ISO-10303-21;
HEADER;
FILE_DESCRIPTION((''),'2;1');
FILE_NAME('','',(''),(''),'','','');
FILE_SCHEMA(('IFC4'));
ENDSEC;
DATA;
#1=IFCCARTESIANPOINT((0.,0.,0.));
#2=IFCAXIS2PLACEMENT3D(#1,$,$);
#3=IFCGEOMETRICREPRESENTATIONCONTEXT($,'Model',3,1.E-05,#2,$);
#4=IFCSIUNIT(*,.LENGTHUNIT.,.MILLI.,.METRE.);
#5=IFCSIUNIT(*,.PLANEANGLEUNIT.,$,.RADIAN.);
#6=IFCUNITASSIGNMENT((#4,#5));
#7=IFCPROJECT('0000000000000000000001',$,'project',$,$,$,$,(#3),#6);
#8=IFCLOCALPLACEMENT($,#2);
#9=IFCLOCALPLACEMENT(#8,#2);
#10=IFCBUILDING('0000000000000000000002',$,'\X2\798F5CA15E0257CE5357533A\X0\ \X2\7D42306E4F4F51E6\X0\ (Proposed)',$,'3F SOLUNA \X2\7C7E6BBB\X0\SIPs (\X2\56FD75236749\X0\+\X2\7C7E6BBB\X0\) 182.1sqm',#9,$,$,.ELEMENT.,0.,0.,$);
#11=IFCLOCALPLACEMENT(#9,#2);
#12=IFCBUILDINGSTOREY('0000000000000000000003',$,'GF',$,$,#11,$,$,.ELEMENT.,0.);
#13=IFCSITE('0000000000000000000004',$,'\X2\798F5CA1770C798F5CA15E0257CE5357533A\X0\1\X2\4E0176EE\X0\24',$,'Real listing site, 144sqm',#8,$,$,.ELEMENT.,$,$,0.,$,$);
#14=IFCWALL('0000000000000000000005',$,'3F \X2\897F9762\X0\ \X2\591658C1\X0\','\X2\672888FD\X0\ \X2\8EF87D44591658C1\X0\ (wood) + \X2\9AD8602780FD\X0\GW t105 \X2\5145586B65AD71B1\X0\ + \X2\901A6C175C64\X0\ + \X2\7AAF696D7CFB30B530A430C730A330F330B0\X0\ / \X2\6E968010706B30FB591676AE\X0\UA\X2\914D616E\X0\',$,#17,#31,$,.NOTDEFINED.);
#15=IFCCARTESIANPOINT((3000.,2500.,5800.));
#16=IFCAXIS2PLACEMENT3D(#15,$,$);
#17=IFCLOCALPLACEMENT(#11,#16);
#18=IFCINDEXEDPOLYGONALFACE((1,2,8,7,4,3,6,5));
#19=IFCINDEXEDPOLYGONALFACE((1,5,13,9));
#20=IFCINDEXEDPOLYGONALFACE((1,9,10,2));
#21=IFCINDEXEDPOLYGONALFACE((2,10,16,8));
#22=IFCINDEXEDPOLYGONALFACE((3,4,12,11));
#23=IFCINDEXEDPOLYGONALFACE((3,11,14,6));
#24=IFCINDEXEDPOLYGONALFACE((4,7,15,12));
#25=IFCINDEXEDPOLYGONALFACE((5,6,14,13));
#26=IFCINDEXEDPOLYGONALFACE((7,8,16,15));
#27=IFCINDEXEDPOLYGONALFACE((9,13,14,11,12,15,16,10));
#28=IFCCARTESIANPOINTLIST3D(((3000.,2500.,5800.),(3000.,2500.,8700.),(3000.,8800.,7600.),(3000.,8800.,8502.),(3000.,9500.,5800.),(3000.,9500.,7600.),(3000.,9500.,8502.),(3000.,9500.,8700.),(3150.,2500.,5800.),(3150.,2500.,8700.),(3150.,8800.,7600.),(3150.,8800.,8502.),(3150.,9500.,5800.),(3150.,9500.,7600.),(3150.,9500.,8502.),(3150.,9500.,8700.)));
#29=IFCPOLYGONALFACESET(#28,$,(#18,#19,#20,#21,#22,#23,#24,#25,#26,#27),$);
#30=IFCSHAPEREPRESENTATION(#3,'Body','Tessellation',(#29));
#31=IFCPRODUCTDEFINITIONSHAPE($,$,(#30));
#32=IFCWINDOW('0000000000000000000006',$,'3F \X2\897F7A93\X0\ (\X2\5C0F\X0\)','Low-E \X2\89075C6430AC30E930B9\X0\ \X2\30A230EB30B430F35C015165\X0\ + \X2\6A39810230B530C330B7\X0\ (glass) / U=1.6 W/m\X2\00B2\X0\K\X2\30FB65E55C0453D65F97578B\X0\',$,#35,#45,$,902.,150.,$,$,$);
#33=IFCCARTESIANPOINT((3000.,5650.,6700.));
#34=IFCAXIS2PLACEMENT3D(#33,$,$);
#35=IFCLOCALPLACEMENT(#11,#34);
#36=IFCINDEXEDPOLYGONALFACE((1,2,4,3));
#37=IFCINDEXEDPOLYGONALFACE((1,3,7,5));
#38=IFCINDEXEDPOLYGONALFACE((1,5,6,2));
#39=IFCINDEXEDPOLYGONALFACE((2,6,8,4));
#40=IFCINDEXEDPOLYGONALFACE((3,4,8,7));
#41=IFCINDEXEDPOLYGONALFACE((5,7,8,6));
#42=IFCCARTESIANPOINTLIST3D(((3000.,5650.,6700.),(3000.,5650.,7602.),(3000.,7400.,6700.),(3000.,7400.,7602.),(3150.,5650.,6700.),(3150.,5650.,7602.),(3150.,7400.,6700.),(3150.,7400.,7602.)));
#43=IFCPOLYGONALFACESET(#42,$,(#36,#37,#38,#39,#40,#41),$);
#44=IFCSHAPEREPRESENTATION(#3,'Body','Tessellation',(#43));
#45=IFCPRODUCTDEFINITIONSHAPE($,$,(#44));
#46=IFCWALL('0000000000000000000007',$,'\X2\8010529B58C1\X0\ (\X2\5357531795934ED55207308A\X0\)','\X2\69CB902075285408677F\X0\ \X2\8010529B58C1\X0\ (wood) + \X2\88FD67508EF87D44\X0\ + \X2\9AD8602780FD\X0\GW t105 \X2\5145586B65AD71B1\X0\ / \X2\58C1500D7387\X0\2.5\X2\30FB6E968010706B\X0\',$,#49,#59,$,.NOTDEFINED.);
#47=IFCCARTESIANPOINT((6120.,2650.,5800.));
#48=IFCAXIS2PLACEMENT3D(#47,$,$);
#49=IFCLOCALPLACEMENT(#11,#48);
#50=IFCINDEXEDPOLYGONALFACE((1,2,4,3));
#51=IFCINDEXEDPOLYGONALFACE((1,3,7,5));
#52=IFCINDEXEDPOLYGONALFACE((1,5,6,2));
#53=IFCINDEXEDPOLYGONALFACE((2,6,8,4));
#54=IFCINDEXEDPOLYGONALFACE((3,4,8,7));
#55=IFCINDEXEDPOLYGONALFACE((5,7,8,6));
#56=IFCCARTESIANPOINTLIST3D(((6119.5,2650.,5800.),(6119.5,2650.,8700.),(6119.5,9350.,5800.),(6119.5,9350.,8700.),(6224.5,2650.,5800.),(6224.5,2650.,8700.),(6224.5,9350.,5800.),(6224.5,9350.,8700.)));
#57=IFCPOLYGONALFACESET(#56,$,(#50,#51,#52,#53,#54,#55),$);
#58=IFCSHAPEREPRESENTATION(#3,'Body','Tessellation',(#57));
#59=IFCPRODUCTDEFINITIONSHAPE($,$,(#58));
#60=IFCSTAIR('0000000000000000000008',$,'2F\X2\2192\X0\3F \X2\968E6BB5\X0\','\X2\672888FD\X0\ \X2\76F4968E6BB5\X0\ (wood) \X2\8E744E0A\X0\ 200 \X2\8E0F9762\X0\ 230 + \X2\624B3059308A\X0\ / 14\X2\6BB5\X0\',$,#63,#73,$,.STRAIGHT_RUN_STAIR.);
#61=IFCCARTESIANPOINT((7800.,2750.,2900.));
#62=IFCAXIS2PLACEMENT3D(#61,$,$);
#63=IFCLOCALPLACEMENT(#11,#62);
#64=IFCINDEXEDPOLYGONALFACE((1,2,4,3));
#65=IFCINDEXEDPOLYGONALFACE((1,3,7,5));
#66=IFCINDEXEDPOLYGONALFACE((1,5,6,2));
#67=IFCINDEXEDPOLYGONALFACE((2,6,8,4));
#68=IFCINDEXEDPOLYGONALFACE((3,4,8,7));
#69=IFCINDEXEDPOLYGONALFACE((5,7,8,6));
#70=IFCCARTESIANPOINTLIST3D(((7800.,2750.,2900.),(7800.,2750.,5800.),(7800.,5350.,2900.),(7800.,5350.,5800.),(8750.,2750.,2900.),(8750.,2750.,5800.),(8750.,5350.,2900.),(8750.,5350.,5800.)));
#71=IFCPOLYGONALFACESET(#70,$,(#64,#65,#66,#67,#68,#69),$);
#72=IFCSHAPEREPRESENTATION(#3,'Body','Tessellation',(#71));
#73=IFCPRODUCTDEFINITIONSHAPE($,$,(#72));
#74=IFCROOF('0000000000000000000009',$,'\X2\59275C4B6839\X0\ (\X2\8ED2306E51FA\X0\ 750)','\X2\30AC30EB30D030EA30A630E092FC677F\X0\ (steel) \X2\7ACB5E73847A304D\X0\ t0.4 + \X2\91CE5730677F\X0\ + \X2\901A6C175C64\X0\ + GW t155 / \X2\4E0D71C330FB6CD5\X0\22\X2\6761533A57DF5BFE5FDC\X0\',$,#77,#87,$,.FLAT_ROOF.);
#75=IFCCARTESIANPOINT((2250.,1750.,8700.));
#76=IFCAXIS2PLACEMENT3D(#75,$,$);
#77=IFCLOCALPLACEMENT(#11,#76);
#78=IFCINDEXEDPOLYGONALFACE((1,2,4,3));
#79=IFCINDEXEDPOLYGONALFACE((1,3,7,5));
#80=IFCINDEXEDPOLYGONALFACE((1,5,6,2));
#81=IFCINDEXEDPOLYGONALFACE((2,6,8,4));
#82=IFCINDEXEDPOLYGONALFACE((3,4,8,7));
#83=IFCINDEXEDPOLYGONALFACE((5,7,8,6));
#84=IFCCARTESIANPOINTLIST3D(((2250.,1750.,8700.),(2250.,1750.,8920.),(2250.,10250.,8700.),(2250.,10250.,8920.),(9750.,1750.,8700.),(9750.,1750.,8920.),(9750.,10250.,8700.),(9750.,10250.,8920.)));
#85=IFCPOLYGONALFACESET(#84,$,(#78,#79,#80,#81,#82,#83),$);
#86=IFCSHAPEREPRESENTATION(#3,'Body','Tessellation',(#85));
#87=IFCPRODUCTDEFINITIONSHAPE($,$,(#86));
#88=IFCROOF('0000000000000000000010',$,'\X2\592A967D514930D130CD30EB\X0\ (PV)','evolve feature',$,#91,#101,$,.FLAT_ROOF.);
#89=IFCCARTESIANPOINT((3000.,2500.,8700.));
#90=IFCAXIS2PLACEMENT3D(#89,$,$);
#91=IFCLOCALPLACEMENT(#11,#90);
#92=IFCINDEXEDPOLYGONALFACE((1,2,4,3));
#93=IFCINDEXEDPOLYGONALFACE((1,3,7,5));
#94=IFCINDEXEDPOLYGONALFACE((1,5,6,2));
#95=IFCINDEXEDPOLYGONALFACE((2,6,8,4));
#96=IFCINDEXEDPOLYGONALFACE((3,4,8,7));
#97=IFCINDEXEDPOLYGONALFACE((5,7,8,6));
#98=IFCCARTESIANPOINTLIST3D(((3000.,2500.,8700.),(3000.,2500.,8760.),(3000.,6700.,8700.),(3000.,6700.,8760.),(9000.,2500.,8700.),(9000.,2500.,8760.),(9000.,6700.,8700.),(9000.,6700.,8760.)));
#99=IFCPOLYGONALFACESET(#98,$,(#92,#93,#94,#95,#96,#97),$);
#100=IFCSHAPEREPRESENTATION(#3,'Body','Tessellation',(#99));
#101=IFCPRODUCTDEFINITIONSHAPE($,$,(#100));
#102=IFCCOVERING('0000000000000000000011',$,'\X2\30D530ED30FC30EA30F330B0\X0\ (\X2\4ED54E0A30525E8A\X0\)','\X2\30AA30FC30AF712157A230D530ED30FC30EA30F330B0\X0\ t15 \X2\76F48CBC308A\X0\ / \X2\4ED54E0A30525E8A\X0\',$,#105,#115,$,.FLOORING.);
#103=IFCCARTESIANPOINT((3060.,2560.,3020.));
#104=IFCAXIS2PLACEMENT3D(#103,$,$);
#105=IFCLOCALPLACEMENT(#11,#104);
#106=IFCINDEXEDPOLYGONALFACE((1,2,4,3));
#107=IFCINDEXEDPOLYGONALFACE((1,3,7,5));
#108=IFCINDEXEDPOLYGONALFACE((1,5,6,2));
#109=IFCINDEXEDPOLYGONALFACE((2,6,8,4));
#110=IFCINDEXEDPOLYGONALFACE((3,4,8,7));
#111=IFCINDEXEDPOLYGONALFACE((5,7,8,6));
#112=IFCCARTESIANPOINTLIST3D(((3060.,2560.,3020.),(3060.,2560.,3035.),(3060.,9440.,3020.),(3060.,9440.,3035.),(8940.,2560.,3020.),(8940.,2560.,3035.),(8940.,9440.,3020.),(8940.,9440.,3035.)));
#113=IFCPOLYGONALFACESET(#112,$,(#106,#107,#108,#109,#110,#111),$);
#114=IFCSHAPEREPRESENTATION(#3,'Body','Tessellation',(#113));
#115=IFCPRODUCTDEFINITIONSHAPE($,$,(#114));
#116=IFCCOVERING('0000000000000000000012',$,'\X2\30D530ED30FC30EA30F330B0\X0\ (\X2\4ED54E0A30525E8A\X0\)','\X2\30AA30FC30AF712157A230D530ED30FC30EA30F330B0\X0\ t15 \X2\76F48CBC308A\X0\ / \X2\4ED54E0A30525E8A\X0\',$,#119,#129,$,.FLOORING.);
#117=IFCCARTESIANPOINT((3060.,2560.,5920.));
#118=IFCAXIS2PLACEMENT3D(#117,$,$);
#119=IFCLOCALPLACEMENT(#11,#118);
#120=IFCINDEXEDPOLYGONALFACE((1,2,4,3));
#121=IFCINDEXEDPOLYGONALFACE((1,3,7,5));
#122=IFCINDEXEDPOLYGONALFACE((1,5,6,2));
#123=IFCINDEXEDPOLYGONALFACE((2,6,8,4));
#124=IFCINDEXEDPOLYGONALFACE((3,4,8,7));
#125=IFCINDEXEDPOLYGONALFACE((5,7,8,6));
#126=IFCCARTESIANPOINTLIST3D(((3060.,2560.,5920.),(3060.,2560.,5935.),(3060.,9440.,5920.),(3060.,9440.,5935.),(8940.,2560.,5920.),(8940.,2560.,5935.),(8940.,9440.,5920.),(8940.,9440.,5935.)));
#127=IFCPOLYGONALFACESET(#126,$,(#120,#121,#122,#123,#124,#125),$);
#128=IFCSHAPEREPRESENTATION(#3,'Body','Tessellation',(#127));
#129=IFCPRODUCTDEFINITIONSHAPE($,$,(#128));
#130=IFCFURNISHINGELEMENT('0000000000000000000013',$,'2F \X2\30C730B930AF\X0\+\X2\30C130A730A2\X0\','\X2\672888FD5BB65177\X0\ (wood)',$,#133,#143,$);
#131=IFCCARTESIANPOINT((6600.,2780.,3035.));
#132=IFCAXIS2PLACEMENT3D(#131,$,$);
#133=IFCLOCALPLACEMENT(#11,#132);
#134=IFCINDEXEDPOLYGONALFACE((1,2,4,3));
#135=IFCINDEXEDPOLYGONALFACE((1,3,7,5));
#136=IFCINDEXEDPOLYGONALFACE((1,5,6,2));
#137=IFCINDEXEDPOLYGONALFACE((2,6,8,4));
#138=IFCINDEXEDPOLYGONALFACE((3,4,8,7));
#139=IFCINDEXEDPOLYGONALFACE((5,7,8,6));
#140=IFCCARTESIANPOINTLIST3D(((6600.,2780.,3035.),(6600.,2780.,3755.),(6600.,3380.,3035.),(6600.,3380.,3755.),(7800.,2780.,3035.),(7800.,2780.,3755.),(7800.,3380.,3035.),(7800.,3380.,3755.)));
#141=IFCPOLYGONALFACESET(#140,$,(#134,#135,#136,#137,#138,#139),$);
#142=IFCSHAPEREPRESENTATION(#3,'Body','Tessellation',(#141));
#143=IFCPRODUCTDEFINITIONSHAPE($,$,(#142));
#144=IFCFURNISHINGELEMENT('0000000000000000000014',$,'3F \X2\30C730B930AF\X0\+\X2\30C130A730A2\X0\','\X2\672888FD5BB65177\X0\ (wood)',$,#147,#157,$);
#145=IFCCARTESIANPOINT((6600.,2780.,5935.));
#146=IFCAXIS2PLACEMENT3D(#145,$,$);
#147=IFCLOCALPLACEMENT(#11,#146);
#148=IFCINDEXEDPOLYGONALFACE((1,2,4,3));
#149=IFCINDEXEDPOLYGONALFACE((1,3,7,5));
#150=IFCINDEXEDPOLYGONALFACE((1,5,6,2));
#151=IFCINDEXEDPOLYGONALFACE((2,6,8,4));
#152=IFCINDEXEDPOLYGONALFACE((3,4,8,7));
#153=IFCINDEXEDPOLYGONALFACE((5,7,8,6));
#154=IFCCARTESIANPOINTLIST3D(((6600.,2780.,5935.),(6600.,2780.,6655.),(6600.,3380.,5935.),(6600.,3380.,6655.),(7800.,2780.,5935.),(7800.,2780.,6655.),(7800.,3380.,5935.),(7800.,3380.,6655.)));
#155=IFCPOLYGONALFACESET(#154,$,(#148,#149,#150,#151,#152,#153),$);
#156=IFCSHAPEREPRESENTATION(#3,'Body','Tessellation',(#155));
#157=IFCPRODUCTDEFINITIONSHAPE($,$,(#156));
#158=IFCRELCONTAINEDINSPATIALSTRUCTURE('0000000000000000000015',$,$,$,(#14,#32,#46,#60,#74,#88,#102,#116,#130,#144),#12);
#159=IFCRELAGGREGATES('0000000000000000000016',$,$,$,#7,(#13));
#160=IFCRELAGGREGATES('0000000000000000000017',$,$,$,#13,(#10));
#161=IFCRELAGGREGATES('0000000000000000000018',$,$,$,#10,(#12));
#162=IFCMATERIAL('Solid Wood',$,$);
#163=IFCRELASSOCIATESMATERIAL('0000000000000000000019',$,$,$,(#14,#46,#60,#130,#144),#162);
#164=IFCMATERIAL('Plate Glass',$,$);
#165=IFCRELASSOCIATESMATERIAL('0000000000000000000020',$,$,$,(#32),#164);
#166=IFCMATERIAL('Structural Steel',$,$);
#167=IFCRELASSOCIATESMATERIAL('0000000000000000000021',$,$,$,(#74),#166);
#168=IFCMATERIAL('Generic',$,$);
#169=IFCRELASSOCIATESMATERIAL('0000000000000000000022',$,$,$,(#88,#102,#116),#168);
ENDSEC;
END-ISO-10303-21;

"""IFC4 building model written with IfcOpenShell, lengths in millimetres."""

from ifc_helpers import new_model, si_unit, frame, frame_2d, origin, place, context, project, spatial, rectangle, extrude, material, element, fill, save


model = new_model("IFC4")

# Units and contexts
model_context = context("Model", 3, precision=1e-05, world=origin())
ifc_project = project(units=[si_unit("LENGTHUNIT", "METRE", prefix="MILLI"), si_unit("PLANEANGLEUNIT", "RADIAN")], contexts=[model_context])

# Site, building, storey
site_placement = place(None, origin())
site = spatial("IfcSite", under=ifc_project, at=site_placement, Name="福岡県福岡市城南区1丁目24", ObjectType="Real listing site, 144sqm", CompositionType="ELEMENT", RefElevation=0.0)
building_placement = place(site_placement, origin())
building = spatial("IfcBuilding", under=site, at=building_placement, Name="福岡市城南区 終の住処 (Proposed)", ObjectType="3F SOLUNA 籾殻SIPs (国産杉+籾殻) 182.1sqm", CompositionType="ELEMENT", ElevationOfRefHeight=0.0, ElevationOfTerrain=0.0)
storey_placement = place(building_placement, origin())
storey = spatial("IfcBuildingStorey", under=building, at=storey_placement, Name="GF", CompositionType="ELEMENT", Elevation=0.0)

# Shared definitions
ifc_material_1 = material(Name="Solid Wood")

# Shared definitions
ifc_material_2 = material(Name="Plate Glass")

# Shared definitions
ifc_material_3 = material(Name="Generic")

# Wall, opening, window
wall_1_placement = place(storey_placement, frame((3000.0, 2500.0, 5800.0)))
wall_1 = element("IfcWall", 1, at=wall_1_placement, inside=storey, material=ifc_material_1, Name="3F 西面 外壁", Description="木製 軸組外壁 (wood) + 高性能GW t105 充填断熱 + 通気層 + 窯業系サイディング / 準耐火・外皮UA配慮", PredefinedType="NOTDEFINED", context=model_context, shape_type="SweptSolid", body=[
    extrude(rectangle(XDim=150.0, YDim=7000.0, at=frame_2d((75.0, 3500.0))), frame((3000.0, 2500.0, 5800.0)), (0.0, 0.0, 1.0), 2900.0),
])
opening_1_placement = place(storey_placement, frame((3000.0, 5650.0, 6700.0)))
opening_1 = element("IfcOpeningElement", 2, at=opening_1_placement, cuts=wall_1, PredefinedType="NOTDEFINED", context=model_context, shape_type="SweptSolid", body=[
    extrude(rectangle(XDim=150.0, YDim=1750.0, at=frame_2d((75.0, 875.0))), frame((3000.0, 5650.0, 6700.0)), (0.0, 0.0, 1.0), 902.0),
])
window_1_placement = place(storey_placement, frame((3000.0, 5650.0, 6700.0)))
window_1 = element("IfcWindow", 3, at=window_1_placement, inside=storey, material=ifc_material_2, Name="3F 西窓 (小)", Description="Low-E 複層ガラス アルゴン封入 + 樹脂サッシ (glass) / U=1.6 W/m²K・日射取得型", OverallHeight=902.0, OverallWidth=150.0, context=model_context, shape_type="SweptSolid", body=[
    extrude(rectangle(XDim=150.0, YDim=1750.0, at=frame_2d((75.0, 875.0))), frame((3000.0, 5650.0, 6700.0)), (0.0, 0.0, 1.0), 902.0),
])
fill(opening_1, window_1)

# Wall
wall_2_placement = place(storey_placement, frame((6120.0, 2650.0, 5800.0)))
element("IfcWall", 4, at=wall_2_placement, inside=storey, material=ifc_material_1, Name="耐力壁 (南北間仕切り)", Description="構造用合板 耐力壁 (wood) + 製材軸組 + 高性能GW t105 充填断熱 / 壁倍率2.5・準耐火", PredefinedType="NOTDEFINED", context=model_context, shape_type="SweptSolid", body=[
    extrude(rectangle(XDim=105.0, YDim=6700.0, at=frame_2d((52.0, 3350.0))), frame((6120.0, 2650.0, 5800.0)), (0.0, 0.0, 1.0), 2900.0),
])

# Stair
stair_placement = place(storey_placement, frame((7800.0, 2750.0, 2900.0)))
element("IfcStair", 5, at=stair_placement, inside=storey, material=ifc_material_1, Name="2F→3F 階段", Description="木製 直階段 (wood) 蹴上 200 踏面 230 + 手すり / 14段", PredefinedType="STRAIGHT_RUN_STAIR", context=model_context, shape_type="SweptSolid", body=[
    extrude(rectangle(XDim=950.0, YDim=2600.0, at=frame_2d((475.0, 1300.0))), frame((7800.0, 2750.0, 2900.0)), (0.0, 0.0, 1.0), 2900.0),
])

# Roofs
ifc_material_4 = material(Name="Structural Steel")
roof_1_placement = place(storey_placement, frame((2250.0, 1750.0, 8700.0)))
element("IfcRoof", 6, at=roof_1_placement, inside=storey, material=ifc_material_4, Name="大屋根 (軒の出 750)", Description="ガルバリウム鋼板 (steel) 立平葺き t0.4 + 野地板 + 通気層 + GW t155 / 不燃・法22条区域対応", PredefinedType="FLAT_ROOF", context=model_context, shape_type="SweptSolid", body=[
    extrude(rectangle(XDim=7500.0, YDim=8500.0, at=frame_2d((3750.0, 4250.0))), frame((2250.0, 1750.0, 8700.0)), (0.0, 0.0, 1.0), 220.0),
])
roof_2_placement = place(storey_placement, frame((3000.0, 2500.0, 8700.0)))
element("IfcRoof", 7, at=roof_2_placement, inside=storey, material=ifc_material_3, Name="太陽光パネル (PV)", Description="evolve feature", PredefinedType="FLAT_ROOF", context=model_context, shape_type="SweptSolid", body=[
    extrude(rectangle(XDim=6000.0, YDim=4200.0, at=frame_2d((3000.0, 2100.0))), frame((3000.0, 2500.0, 8700.0)), (0.0, 0.0, 1.0), 60.0),
])

# Coverings
covering_1_placement = place(storey_placement, frame((3060.0, 2560.0, 3020.0)))
element("IfcCovering", 8, at=covering_1_placement, inside=storey, material=ifc_material_3, Name="フローリング (仕上げ床)", Description="オーク無垢フローリング t15 直貼り / 仕上げ床", PredefinedType="FLOORING", context=model_context, shape_type="SweptSolid", body=[
    extrude(rectangle(XDim=5880.0, YDim=6880.0, at=frame_2d((2940.0, 3440.0))), frame((3060.0, 2560.0, 3020.0)), (0.0, 0.0, 1.0), 15.0),
])
covering_2_placement = place(storey_placement, frame((3060.0, 2560.0, 5920.0)))
element("IfcCovering", 9, at=covering_2_placement, inside=storey, material=ifc_material_3, Name="フローリング (仕上げ床)", Description="オーク無垢フローリング t15 直貼り / 仕上げ床", PredefinedType="FLOORING", context=model_context, shape_type="SweptSolid", body=[
    extrude(rectangle(XDim=5880.0, YDim=6880.0, at=frame_2d((2940.0, 3440.0))), frame((3060.0, 2560.0, 5920.0)), (0.0, 0.0, 1.0), 15.0),
])

# Furnishing elements
furnishing_1_placement = place(storey_placement, frame((6600.0, 2780.0, 3035.0)))
element("IfcFurnishingElement", 10, at=furnishing_1_placement, inside=storey, material=ifc_material_1, Name="2F デスク+チェア", Description="木製家具 (wood)", context=model_context, shape_type="SweptSolid", body=[
    extrude(rectangle(XDim=1200.0, YDim=600.0, at=frame_2d((600.0, 300.0))), frame((6600.0, 2780.0, 3035.0)), (0.0, 0.0, 1.0), 720.0),
])
furnishing_2_placement = place(storey_placement, frame((6600.0, 2780.0, 5935.0)))
element("IfcFurnishingElement", 11, at=furnishing_2_placement, inside=storey, material=ifc_material_1, Name="3F デスク+チェア", Description="木製家具 (wood)", context=model_context, shape_type="SweptSolid", body=[
    extrude(rectangle(XDim=1200.0, YDim=600.0, at=frame_2d((600.0, 300.0))), frame((6600.0, 2780.0, 5935.0)), (0.0, 0.0, 1.0), 720.0),
])

save(model, "model.ifc")
